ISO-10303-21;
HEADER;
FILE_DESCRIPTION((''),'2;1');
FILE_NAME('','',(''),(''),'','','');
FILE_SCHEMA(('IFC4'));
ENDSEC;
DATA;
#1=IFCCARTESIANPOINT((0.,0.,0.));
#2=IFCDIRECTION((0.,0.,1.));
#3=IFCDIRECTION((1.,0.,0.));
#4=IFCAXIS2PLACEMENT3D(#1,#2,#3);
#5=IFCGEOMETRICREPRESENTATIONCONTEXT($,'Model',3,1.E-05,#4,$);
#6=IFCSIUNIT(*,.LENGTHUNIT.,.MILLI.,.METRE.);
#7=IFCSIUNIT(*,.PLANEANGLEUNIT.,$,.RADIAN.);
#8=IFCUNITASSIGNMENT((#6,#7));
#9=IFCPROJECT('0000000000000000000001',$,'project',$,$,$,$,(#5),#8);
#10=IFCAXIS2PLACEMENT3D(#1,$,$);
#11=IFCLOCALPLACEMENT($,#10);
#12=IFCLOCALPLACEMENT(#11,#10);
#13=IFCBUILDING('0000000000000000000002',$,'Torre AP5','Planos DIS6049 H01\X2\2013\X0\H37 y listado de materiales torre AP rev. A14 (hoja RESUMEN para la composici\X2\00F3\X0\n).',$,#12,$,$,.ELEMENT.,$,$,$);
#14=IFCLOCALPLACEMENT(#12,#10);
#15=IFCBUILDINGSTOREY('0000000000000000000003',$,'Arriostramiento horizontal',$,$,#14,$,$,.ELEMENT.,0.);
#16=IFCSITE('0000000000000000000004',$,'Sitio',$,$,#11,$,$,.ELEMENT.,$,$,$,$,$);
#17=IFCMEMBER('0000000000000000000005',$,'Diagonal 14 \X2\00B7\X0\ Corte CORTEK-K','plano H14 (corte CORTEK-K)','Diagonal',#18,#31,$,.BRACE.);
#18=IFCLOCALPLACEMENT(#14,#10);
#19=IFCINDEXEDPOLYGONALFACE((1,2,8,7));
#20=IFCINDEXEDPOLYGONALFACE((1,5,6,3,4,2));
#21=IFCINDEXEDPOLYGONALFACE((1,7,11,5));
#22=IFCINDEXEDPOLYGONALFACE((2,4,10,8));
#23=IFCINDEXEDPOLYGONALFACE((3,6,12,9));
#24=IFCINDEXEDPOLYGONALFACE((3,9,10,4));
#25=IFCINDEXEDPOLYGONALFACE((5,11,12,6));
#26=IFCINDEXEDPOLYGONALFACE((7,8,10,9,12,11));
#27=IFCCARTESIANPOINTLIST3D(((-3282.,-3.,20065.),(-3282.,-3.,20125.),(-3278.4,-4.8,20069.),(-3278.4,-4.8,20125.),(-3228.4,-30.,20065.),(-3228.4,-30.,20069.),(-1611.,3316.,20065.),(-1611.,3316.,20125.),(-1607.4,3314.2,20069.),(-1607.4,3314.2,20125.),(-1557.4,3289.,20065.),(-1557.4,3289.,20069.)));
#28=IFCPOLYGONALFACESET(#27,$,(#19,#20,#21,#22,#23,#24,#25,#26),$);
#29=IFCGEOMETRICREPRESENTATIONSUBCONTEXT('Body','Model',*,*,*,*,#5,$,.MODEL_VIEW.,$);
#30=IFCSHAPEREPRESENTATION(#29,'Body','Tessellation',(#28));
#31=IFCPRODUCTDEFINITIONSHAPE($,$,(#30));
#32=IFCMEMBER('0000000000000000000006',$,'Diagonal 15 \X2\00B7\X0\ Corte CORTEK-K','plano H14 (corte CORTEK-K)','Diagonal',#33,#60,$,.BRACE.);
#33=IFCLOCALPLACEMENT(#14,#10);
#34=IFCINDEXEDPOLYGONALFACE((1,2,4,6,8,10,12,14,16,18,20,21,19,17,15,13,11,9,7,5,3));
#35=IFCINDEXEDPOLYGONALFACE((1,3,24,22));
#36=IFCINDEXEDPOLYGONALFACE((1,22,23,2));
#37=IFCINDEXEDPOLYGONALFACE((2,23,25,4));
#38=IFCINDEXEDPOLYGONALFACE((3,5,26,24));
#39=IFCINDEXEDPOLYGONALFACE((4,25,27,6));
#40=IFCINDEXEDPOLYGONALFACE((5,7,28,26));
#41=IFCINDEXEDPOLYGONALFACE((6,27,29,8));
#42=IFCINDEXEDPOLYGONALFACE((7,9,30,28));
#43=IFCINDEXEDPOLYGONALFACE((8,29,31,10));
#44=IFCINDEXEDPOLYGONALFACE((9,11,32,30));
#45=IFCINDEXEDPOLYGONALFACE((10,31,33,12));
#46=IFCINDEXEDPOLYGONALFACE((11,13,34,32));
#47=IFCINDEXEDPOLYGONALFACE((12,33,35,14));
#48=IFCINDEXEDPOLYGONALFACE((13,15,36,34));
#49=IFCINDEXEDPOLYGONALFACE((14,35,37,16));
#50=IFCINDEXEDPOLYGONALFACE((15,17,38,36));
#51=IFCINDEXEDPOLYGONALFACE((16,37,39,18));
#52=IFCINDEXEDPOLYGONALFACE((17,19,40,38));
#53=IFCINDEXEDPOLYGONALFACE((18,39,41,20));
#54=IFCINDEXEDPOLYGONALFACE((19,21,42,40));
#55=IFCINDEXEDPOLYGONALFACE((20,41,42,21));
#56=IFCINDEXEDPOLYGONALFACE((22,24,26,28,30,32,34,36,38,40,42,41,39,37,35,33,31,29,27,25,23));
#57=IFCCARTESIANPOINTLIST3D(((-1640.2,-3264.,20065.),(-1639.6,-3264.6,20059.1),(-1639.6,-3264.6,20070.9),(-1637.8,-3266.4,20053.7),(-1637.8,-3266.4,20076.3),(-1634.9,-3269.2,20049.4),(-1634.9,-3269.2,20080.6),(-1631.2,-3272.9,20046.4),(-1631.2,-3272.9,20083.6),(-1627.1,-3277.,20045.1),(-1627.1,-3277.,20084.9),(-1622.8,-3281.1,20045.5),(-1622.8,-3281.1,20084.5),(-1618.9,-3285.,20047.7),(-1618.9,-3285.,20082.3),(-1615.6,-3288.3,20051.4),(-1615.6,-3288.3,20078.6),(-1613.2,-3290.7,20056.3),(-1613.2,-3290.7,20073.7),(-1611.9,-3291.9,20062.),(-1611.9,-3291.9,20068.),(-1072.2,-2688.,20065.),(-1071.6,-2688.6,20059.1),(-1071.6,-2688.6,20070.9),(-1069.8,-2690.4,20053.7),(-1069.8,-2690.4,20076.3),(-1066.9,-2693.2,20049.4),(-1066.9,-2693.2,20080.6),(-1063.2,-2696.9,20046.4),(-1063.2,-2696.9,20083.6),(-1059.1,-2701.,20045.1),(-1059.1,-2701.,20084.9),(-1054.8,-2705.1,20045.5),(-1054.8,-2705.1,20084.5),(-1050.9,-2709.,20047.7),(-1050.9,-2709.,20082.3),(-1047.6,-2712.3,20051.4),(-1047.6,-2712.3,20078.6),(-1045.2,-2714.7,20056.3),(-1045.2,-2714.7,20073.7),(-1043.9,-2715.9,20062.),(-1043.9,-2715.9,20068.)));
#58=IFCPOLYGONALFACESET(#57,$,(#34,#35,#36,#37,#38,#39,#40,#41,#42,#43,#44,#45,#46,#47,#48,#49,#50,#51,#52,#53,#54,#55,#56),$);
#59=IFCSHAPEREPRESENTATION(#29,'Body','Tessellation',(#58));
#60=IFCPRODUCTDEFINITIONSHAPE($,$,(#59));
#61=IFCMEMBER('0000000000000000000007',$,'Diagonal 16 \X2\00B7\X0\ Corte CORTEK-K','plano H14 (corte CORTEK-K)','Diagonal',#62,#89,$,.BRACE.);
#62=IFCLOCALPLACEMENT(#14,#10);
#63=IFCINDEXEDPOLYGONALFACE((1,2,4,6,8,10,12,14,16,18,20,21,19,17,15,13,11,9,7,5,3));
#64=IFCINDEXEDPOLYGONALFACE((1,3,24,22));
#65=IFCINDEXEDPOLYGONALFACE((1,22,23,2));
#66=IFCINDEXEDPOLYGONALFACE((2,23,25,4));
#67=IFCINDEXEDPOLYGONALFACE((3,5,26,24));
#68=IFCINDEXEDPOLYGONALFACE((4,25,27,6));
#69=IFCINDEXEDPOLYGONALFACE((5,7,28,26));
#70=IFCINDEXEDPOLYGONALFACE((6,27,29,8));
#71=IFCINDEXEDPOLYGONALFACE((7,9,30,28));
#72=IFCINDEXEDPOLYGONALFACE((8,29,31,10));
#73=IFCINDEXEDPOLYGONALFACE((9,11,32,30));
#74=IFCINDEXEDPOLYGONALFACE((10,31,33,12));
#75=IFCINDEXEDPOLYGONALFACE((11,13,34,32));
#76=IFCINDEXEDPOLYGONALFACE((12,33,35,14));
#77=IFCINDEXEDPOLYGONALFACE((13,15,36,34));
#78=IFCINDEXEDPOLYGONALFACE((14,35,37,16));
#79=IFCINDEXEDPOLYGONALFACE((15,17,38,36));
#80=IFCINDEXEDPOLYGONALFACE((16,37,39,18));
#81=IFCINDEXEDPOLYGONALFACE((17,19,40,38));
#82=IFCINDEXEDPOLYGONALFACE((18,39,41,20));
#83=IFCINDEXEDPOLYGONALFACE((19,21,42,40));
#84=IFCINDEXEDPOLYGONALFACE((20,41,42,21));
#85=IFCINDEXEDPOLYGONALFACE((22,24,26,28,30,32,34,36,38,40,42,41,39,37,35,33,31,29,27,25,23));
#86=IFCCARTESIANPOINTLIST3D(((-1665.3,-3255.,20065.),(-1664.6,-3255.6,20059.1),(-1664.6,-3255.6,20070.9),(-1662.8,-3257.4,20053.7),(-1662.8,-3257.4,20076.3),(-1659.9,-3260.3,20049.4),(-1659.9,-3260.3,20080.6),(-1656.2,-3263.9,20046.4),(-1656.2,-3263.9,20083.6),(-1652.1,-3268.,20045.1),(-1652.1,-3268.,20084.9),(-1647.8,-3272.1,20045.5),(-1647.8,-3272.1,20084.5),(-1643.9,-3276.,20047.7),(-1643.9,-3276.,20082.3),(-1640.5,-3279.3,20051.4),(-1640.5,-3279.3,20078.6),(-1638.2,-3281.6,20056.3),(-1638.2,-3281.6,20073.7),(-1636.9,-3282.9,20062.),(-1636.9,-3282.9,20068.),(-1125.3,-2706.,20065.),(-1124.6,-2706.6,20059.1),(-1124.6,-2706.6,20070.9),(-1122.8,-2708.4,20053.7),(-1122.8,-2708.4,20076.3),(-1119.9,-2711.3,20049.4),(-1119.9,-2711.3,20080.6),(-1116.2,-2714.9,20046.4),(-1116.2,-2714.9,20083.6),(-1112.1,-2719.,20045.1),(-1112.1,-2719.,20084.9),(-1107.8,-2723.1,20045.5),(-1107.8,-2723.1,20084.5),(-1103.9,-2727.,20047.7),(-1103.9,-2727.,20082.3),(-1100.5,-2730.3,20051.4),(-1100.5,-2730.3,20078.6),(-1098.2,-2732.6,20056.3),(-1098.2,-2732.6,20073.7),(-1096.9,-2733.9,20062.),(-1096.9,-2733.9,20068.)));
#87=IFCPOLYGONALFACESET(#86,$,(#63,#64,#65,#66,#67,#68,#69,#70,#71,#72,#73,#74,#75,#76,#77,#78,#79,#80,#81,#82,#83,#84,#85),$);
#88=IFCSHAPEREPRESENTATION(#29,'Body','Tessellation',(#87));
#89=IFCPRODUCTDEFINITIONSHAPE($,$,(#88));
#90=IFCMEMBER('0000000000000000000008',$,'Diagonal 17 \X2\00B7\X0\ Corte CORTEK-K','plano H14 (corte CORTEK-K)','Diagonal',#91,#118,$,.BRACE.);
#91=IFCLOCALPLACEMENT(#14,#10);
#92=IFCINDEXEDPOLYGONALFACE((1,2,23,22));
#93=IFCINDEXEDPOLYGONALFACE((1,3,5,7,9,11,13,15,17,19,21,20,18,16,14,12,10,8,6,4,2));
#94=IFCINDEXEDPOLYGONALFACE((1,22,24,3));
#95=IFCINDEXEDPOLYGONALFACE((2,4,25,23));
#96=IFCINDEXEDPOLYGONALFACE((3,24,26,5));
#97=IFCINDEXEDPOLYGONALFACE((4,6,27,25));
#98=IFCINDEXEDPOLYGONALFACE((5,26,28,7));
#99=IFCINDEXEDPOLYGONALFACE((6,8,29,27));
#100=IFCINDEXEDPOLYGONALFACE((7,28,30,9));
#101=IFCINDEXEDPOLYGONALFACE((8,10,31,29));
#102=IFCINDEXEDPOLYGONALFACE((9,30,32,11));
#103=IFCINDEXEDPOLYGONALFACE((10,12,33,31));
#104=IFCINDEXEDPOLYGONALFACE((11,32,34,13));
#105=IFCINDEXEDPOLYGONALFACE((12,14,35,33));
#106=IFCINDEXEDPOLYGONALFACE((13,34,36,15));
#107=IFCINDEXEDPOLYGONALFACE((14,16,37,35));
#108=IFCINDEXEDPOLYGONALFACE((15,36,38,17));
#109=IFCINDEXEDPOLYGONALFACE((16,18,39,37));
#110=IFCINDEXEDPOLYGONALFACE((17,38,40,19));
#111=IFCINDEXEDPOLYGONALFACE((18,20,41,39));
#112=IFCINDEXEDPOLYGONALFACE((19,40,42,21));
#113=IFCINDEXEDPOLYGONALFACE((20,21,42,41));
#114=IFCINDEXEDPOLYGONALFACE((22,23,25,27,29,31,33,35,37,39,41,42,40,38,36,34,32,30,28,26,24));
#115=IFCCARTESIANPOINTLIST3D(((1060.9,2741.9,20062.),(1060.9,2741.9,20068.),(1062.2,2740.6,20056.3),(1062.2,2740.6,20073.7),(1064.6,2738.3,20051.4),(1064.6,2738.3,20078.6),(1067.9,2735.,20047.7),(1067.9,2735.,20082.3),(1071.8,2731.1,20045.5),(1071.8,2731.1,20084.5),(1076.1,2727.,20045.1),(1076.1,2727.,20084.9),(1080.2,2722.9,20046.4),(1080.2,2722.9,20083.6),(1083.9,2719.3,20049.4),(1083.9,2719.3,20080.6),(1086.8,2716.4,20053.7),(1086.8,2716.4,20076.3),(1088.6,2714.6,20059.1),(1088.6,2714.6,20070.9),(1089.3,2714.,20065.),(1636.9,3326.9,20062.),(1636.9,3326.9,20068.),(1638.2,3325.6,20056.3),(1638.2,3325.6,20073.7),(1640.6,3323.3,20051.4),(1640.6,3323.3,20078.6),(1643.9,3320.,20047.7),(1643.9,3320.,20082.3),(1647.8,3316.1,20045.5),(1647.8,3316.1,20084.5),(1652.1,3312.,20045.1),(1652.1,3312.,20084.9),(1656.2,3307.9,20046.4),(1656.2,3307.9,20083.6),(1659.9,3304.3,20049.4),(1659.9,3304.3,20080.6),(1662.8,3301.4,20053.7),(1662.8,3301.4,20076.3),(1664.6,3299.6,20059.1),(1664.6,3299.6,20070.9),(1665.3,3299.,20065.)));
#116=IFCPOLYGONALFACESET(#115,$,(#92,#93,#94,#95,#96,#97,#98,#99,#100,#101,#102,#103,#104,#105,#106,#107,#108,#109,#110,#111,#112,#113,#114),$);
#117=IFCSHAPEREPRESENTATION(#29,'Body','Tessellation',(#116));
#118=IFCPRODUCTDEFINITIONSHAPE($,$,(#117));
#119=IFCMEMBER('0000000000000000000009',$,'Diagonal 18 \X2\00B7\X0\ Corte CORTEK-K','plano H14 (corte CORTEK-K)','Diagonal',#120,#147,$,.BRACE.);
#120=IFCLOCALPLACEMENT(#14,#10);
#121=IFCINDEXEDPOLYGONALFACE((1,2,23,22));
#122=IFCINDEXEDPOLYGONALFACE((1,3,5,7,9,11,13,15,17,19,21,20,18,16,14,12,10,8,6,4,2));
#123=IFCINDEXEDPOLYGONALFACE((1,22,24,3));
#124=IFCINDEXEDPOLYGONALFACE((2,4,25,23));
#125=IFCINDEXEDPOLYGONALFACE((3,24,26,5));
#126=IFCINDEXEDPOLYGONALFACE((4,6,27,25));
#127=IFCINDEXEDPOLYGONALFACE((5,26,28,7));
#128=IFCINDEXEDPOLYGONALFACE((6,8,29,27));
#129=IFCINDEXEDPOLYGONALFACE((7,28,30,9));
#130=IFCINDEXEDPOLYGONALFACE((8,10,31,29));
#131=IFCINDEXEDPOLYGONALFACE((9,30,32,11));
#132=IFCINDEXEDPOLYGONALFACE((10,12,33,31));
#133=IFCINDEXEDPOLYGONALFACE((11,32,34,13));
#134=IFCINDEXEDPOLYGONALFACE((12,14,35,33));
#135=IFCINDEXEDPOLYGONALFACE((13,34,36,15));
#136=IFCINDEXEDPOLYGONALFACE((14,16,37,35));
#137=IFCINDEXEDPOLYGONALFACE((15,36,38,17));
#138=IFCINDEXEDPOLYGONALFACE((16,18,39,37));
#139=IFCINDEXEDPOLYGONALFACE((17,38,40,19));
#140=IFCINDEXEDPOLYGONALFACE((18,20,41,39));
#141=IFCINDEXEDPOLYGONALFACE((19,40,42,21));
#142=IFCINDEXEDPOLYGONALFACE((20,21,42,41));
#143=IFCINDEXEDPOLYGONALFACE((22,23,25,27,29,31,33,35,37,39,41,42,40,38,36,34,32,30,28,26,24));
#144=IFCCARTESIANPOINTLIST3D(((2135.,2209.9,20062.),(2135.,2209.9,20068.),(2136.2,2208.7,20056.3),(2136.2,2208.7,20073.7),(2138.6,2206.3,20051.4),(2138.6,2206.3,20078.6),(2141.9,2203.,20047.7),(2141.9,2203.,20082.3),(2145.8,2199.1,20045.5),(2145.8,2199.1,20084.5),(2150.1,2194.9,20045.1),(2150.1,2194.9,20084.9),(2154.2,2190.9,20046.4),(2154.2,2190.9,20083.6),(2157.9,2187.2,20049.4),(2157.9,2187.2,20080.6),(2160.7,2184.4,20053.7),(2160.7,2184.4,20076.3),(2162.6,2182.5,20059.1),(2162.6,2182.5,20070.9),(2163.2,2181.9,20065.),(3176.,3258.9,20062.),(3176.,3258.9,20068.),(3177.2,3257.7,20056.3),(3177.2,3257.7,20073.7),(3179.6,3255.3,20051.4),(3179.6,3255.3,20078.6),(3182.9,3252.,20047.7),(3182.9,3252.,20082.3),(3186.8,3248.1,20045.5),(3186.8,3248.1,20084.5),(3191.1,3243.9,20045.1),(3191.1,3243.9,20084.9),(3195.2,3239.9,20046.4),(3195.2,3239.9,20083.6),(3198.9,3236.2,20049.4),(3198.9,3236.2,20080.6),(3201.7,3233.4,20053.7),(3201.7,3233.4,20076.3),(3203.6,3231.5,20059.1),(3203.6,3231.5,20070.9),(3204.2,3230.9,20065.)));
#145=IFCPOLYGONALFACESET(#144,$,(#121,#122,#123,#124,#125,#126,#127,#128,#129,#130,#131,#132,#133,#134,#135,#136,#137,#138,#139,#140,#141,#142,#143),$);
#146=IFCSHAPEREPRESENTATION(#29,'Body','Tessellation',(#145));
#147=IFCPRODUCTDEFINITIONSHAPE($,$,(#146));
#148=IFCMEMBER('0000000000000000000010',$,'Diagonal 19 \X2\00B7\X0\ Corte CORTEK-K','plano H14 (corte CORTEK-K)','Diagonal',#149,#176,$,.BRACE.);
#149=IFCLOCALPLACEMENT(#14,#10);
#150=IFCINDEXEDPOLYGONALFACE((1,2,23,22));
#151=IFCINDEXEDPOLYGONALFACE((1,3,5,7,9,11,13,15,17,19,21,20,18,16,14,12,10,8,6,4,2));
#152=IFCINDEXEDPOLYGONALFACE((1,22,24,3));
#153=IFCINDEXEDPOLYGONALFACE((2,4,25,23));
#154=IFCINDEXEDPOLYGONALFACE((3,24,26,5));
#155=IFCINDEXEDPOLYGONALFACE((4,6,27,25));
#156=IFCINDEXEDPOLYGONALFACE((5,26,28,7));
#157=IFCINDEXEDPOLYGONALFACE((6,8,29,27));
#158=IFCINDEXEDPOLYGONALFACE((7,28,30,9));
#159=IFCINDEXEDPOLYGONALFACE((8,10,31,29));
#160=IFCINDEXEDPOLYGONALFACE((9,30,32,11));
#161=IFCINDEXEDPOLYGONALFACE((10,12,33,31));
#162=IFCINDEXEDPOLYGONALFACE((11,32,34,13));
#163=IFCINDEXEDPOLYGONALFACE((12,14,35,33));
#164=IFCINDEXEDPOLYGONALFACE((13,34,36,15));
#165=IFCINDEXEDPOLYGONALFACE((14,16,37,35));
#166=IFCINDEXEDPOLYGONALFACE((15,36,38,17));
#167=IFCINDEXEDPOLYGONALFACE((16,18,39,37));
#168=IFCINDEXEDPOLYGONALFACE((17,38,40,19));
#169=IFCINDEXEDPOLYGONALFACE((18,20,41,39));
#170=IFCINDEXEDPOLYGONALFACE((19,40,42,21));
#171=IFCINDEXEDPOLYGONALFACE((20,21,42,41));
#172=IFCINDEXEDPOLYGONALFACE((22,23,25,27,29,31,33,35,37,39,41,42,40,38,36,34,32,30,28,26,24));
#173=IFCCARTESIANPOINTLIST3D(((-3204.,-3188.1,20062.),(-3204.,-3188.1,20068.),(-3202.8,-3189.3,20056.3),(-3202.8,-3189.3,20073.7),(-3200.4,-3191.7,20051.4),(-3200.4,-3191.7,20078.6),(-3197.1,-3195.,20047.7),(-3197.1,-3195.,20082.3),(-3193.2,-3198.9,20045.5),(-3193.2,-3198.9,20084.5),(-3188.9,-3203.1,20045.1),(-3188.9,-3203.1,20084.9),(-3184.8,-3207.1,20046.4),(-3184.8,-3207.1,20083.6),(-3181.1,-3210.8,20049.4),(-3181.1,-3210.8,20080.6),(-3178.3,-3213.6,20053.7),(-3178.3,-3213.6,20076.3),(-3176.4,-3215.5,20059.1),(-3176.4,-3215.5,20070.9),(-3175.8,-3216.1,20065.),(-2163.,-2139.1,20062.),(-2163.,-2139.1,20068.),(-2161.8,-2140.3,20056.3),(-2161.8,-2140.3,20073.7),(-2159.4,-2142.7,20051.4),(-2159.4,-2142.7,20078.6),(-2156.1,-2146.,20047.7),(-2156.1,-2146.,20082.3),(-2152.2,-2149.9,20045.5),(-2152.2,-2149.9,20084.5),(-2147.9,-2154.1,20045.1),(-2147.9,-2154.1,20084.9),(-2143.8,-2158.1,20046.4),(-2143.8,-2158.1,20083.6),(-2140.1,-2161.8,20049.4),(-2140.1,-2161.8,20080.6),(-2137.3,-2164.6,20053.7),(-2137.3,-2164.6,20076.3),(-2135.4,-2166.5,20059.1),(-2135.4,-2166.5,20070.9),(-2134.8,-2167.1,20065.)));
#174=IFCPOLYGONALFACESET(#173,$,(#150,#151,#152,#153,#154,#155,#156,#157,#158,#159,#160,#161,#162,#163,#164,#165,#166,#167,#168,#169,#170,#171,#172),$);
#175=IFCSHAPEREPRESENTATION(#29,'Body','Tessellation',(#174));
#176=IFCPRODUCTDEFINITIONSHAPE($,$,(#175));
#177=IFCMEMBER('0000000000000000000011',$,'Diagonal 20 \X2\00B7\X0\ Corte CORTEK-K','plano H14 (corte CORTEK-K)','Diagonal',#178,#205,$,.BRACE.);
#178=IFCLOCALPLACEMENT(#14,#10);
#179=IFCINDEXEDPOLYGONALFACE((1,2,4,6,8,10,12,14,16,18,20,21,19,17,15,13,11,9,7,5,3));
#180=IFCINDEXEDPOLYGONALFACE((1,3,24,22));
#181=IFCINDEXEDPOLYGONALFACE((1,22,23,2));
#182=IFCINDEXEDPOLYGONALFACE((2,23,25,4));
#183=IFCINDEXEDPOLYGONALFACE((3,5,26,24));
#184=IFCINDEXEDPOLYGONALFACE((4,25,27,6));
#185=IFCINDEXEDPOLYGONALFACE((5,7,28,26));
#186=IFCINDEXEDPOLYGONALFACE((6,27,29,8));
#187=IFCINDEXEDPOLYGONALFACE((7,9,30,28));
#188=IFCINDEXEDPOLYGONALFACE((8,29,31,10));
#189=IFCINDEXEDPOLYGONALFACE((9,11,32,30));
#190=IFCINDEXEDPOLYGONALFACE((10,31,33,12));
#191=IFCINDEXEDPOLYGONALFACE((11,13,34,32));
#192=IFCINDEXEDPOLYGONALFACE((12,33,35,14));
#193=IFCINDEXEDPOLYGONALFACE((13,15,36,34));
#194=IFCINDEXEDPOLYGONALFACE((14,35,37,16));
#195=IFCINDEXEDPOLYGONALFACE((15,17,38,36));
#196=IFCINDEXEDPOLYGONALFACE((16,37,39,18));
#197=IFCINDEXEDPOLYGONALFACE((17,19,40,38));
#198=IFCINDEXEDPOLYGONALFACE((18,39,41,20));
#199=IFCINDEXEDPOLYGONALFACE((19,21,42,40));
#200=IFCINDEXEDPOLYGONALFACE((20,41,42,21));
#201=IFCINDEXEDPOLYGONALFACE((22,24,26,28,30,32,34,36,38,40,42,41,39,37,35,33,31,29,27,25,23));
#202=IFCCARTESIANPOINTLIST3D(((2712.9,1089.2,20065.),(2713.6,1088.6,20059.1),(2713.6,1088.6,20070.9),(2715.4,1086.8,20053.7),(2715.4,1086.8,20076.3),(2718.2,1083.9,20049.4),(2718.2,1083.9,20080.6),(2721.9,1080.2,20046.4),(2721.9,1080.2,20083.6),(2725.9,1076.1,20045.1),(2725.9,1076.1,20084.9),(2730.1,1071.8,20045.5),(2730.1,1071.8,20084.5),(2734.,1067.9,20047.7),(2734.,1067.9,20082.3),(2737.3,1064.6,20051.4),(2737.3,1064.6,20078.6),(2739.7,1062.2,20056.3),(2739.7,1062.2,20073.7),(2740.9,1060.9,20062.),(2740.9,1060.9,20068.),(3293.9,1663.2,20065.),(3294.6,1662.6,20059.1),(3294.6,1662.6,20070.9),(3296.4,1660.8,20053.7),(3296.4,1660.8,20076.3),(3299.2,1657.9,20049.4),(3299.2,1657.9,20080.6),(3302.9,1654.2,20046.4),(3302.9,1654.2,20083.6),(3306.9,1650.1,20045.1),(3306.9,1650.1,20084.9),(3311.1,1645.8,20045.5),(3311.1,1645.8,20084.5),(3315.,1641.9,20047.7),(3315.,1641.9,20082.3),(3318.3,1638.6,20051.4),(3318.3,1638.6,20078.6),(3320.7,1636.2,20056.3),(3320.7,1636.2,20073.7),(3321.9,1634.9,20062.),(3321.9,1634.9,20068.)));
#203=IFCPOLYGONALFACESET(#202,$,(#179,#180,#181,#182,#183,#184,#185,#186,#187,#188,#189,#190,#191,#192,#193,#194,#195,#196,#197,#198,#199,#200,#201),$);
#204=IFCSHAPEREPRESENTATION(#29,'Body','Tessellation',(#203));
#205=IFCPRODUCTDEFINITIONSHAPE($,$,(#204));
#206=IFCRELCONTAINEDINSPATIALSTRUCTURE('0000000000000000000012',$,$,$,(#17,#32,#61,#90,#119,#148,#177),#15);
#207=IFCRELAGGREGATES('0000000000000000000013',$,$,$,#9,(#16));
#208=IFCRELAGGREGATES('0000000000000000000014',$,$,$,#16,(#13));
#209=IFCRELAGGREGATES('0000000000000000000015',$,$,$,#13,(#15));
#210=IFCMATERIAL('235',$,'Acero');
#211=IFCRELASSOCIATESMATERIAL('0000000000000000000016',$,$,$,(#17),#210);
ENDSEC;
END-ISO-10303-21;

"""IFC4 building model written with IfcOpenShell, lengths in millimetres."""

from ifc_helpers import new_model, si_unit, frame, frame_2d, origin, origin_with_axes, place, context, subcontext, project, spatial, circle, l_section, extrude, material, element, save


model = new_model("IFC4")

# Units and contexts
model_context = context("Model", 3, precision=1e-05, world=origin_with_axes())
body_context = subcontext(model_context, "Body", "Model", "MODEL_VIEW")
ifc_project = project(units=[si_unit("LENGTHUNIT", "METRE", prefix="MILLI"), si_unit("PLANEANGLEUNIT", "RADIAN")], contexts=[model_context])

# Site, building, storey
site_placement = place(None, origin())
site = spatial("IfcSite", under=ifc_project, at=site_placement, Name="Sitio", CompositionType="ELEMENT")
building_placement = place(site_placement, origin())
building = spatial("IfcBuilding", under=site, at=building_placement, Name="Torre AP5", Description="Planos DIS6049 H01–H37 y listado de materiales torre AP rev. A14 (hoja RESUMEN para la composición).", CompositionType="ELEMENT")
storey_placement = place(building_placement, origin())
storey = spatial("IfcBuildingStorey", under=building, at=storey_placement, Name="Arriostramiento horizontal", CompositionType="ELEMENT", Elevation=0.0)

# Members
ifc_material = material(Name="235", Category="Acero")
member_1_placement = place(storey_placement, frame((-1611.0, 3316.0, 20065.0), z_axis=(-0.449688, -0.893186, 0.0), x_axis=(0.893186, -0.449688, 0.0)))
element("IfcMember", 1, at=member_1_placement, inside=storey, material=ifc_material, Name="Diagonal 14 · Corte CORTEK-K", Description="plano H14 (corte CORTEK-K)", ObjectType="Diagonal", PredefinedType="BRACE", context=body_context, shape_type="SweptSolid", body=[
    extrude(l_section(Depth=60.0, Width=60.0, Thickness=4.0, at=frame_2d((30.0, 30.0))), None, (0.0, 0.0, 1.0), 3715.9),
])
member_2_placement = place(storey_placement, frame((-1058.0, -2702.0, 20065.0), z_axis=(-0.702145, -0.712034, 0.0), x_axis=(-0.712034, 0.702145, 0.0)))
element("IfcMember", 2, at=member_2_placement, inside=storey, Name="Diagonal 15 · Corte CORTEK-K", Description="plano H14 (corte CORTEK-K)", ObjectType="Diagonal", PredefinedType="BRACE", context=body_context, shape_type="SweptSolid", body=[
    extrude(circle(Radius=20.0), None, (0.0, 0.0, 1.0), 808.9),
])
member_3_placement = place(storey_placement, frame((-1111.0, -2720.0, 20065.0), z_axis=(-0.701239, -0.712926, 0.0), x_axis=(-0.712926, 0.701239, 0.0)))
element("IfcMember", 3, at=member_3_placement, inside=storey, Name="Diagonal 16 · Corte CORTEK-K", Description="plano H14 (corte CORTEK-K)", ObjectType="Diagonal", PredefinedType="BRACE", context=body_context, shape_type="SweptSolid", body=[
    extrude(circle(Radius=20.0), None, (0.0, 0.0, 1.0), 770.1),
])
member_4_placement = place(storey_placement, frame((1651.0, 3313.0, 20065.0), z_axis=(-0.701604, -0.712567, 0.0), x_axis=(0.712567, -0.701604, 0.0)))
element("IfcMember", 4, at=member_4_placement, inside=storey, Name="Diagonal 17 · Corte CORTEK-K", Description="plano H14 (corte CORTEK-K)", ObjectType="Diagonal", PredefinedType="BRACE", context=body_context, shape_type="SweptSolid", body=[
    extrude(circle(Radius=20.0), None, (0.0, 0.0, 1.0), 821.0),
])
for number, where, z_axis, x_axis, name in (
    (5, (3190.0, 3245.0, 20065.0), (-0.704395, -0.709808, 0.0), (0.709808, -0.704395, 0.0), "Diagonal 18 · Corte CORTEK-K"),
    (6, (-2149.0, -2153.0, 20065.0), (-0.704395, -0.709808, 0.0), (0.709808, -0.704395, 0.0), "Diagonal 19 · Corte CORTEK-K"),
):
    element("IfcMember", number, at=place(storey_placement, frame(where, z_axis=z_axis, x_axis=x_axis)), inside=storey, Name=name, Description="plano H14 (corte CORTEK-K)", ObjectType="Diagonal", PredefinedType="BRACE", context=body_context, shape_type="SweptSolid", body=[
        extrude(circle(Radius=20.0), None, (0.0, 0.0, 1.0), 1477.9),
    ])
for number, where, z_axis, x_axis, name in (
    (7, (3308.0, 1649.0, 20065.0), (-0.711379, -0.702808, 0.0), (-0.702808, 0.711379, 0.0), "Diagonal 20 · Corte CORTEK-K"),
):
    element("IfcMember", number, at=place(storey_placement, frame(where, z_axis=z_axis, x_axis=x_axis)), inside=storey, Name=name, Description="plano H14 (corte CORTEK-K)", ObjectType="Diagonal", PredefinedType="BRACE", context=body_context, shape_type="SweptSolid", body=[
        extrude(circle(Radius=20.0), None, (0.0, 0.0, 1.0), 816.7),
    ])

save(model, "model.ifc")
